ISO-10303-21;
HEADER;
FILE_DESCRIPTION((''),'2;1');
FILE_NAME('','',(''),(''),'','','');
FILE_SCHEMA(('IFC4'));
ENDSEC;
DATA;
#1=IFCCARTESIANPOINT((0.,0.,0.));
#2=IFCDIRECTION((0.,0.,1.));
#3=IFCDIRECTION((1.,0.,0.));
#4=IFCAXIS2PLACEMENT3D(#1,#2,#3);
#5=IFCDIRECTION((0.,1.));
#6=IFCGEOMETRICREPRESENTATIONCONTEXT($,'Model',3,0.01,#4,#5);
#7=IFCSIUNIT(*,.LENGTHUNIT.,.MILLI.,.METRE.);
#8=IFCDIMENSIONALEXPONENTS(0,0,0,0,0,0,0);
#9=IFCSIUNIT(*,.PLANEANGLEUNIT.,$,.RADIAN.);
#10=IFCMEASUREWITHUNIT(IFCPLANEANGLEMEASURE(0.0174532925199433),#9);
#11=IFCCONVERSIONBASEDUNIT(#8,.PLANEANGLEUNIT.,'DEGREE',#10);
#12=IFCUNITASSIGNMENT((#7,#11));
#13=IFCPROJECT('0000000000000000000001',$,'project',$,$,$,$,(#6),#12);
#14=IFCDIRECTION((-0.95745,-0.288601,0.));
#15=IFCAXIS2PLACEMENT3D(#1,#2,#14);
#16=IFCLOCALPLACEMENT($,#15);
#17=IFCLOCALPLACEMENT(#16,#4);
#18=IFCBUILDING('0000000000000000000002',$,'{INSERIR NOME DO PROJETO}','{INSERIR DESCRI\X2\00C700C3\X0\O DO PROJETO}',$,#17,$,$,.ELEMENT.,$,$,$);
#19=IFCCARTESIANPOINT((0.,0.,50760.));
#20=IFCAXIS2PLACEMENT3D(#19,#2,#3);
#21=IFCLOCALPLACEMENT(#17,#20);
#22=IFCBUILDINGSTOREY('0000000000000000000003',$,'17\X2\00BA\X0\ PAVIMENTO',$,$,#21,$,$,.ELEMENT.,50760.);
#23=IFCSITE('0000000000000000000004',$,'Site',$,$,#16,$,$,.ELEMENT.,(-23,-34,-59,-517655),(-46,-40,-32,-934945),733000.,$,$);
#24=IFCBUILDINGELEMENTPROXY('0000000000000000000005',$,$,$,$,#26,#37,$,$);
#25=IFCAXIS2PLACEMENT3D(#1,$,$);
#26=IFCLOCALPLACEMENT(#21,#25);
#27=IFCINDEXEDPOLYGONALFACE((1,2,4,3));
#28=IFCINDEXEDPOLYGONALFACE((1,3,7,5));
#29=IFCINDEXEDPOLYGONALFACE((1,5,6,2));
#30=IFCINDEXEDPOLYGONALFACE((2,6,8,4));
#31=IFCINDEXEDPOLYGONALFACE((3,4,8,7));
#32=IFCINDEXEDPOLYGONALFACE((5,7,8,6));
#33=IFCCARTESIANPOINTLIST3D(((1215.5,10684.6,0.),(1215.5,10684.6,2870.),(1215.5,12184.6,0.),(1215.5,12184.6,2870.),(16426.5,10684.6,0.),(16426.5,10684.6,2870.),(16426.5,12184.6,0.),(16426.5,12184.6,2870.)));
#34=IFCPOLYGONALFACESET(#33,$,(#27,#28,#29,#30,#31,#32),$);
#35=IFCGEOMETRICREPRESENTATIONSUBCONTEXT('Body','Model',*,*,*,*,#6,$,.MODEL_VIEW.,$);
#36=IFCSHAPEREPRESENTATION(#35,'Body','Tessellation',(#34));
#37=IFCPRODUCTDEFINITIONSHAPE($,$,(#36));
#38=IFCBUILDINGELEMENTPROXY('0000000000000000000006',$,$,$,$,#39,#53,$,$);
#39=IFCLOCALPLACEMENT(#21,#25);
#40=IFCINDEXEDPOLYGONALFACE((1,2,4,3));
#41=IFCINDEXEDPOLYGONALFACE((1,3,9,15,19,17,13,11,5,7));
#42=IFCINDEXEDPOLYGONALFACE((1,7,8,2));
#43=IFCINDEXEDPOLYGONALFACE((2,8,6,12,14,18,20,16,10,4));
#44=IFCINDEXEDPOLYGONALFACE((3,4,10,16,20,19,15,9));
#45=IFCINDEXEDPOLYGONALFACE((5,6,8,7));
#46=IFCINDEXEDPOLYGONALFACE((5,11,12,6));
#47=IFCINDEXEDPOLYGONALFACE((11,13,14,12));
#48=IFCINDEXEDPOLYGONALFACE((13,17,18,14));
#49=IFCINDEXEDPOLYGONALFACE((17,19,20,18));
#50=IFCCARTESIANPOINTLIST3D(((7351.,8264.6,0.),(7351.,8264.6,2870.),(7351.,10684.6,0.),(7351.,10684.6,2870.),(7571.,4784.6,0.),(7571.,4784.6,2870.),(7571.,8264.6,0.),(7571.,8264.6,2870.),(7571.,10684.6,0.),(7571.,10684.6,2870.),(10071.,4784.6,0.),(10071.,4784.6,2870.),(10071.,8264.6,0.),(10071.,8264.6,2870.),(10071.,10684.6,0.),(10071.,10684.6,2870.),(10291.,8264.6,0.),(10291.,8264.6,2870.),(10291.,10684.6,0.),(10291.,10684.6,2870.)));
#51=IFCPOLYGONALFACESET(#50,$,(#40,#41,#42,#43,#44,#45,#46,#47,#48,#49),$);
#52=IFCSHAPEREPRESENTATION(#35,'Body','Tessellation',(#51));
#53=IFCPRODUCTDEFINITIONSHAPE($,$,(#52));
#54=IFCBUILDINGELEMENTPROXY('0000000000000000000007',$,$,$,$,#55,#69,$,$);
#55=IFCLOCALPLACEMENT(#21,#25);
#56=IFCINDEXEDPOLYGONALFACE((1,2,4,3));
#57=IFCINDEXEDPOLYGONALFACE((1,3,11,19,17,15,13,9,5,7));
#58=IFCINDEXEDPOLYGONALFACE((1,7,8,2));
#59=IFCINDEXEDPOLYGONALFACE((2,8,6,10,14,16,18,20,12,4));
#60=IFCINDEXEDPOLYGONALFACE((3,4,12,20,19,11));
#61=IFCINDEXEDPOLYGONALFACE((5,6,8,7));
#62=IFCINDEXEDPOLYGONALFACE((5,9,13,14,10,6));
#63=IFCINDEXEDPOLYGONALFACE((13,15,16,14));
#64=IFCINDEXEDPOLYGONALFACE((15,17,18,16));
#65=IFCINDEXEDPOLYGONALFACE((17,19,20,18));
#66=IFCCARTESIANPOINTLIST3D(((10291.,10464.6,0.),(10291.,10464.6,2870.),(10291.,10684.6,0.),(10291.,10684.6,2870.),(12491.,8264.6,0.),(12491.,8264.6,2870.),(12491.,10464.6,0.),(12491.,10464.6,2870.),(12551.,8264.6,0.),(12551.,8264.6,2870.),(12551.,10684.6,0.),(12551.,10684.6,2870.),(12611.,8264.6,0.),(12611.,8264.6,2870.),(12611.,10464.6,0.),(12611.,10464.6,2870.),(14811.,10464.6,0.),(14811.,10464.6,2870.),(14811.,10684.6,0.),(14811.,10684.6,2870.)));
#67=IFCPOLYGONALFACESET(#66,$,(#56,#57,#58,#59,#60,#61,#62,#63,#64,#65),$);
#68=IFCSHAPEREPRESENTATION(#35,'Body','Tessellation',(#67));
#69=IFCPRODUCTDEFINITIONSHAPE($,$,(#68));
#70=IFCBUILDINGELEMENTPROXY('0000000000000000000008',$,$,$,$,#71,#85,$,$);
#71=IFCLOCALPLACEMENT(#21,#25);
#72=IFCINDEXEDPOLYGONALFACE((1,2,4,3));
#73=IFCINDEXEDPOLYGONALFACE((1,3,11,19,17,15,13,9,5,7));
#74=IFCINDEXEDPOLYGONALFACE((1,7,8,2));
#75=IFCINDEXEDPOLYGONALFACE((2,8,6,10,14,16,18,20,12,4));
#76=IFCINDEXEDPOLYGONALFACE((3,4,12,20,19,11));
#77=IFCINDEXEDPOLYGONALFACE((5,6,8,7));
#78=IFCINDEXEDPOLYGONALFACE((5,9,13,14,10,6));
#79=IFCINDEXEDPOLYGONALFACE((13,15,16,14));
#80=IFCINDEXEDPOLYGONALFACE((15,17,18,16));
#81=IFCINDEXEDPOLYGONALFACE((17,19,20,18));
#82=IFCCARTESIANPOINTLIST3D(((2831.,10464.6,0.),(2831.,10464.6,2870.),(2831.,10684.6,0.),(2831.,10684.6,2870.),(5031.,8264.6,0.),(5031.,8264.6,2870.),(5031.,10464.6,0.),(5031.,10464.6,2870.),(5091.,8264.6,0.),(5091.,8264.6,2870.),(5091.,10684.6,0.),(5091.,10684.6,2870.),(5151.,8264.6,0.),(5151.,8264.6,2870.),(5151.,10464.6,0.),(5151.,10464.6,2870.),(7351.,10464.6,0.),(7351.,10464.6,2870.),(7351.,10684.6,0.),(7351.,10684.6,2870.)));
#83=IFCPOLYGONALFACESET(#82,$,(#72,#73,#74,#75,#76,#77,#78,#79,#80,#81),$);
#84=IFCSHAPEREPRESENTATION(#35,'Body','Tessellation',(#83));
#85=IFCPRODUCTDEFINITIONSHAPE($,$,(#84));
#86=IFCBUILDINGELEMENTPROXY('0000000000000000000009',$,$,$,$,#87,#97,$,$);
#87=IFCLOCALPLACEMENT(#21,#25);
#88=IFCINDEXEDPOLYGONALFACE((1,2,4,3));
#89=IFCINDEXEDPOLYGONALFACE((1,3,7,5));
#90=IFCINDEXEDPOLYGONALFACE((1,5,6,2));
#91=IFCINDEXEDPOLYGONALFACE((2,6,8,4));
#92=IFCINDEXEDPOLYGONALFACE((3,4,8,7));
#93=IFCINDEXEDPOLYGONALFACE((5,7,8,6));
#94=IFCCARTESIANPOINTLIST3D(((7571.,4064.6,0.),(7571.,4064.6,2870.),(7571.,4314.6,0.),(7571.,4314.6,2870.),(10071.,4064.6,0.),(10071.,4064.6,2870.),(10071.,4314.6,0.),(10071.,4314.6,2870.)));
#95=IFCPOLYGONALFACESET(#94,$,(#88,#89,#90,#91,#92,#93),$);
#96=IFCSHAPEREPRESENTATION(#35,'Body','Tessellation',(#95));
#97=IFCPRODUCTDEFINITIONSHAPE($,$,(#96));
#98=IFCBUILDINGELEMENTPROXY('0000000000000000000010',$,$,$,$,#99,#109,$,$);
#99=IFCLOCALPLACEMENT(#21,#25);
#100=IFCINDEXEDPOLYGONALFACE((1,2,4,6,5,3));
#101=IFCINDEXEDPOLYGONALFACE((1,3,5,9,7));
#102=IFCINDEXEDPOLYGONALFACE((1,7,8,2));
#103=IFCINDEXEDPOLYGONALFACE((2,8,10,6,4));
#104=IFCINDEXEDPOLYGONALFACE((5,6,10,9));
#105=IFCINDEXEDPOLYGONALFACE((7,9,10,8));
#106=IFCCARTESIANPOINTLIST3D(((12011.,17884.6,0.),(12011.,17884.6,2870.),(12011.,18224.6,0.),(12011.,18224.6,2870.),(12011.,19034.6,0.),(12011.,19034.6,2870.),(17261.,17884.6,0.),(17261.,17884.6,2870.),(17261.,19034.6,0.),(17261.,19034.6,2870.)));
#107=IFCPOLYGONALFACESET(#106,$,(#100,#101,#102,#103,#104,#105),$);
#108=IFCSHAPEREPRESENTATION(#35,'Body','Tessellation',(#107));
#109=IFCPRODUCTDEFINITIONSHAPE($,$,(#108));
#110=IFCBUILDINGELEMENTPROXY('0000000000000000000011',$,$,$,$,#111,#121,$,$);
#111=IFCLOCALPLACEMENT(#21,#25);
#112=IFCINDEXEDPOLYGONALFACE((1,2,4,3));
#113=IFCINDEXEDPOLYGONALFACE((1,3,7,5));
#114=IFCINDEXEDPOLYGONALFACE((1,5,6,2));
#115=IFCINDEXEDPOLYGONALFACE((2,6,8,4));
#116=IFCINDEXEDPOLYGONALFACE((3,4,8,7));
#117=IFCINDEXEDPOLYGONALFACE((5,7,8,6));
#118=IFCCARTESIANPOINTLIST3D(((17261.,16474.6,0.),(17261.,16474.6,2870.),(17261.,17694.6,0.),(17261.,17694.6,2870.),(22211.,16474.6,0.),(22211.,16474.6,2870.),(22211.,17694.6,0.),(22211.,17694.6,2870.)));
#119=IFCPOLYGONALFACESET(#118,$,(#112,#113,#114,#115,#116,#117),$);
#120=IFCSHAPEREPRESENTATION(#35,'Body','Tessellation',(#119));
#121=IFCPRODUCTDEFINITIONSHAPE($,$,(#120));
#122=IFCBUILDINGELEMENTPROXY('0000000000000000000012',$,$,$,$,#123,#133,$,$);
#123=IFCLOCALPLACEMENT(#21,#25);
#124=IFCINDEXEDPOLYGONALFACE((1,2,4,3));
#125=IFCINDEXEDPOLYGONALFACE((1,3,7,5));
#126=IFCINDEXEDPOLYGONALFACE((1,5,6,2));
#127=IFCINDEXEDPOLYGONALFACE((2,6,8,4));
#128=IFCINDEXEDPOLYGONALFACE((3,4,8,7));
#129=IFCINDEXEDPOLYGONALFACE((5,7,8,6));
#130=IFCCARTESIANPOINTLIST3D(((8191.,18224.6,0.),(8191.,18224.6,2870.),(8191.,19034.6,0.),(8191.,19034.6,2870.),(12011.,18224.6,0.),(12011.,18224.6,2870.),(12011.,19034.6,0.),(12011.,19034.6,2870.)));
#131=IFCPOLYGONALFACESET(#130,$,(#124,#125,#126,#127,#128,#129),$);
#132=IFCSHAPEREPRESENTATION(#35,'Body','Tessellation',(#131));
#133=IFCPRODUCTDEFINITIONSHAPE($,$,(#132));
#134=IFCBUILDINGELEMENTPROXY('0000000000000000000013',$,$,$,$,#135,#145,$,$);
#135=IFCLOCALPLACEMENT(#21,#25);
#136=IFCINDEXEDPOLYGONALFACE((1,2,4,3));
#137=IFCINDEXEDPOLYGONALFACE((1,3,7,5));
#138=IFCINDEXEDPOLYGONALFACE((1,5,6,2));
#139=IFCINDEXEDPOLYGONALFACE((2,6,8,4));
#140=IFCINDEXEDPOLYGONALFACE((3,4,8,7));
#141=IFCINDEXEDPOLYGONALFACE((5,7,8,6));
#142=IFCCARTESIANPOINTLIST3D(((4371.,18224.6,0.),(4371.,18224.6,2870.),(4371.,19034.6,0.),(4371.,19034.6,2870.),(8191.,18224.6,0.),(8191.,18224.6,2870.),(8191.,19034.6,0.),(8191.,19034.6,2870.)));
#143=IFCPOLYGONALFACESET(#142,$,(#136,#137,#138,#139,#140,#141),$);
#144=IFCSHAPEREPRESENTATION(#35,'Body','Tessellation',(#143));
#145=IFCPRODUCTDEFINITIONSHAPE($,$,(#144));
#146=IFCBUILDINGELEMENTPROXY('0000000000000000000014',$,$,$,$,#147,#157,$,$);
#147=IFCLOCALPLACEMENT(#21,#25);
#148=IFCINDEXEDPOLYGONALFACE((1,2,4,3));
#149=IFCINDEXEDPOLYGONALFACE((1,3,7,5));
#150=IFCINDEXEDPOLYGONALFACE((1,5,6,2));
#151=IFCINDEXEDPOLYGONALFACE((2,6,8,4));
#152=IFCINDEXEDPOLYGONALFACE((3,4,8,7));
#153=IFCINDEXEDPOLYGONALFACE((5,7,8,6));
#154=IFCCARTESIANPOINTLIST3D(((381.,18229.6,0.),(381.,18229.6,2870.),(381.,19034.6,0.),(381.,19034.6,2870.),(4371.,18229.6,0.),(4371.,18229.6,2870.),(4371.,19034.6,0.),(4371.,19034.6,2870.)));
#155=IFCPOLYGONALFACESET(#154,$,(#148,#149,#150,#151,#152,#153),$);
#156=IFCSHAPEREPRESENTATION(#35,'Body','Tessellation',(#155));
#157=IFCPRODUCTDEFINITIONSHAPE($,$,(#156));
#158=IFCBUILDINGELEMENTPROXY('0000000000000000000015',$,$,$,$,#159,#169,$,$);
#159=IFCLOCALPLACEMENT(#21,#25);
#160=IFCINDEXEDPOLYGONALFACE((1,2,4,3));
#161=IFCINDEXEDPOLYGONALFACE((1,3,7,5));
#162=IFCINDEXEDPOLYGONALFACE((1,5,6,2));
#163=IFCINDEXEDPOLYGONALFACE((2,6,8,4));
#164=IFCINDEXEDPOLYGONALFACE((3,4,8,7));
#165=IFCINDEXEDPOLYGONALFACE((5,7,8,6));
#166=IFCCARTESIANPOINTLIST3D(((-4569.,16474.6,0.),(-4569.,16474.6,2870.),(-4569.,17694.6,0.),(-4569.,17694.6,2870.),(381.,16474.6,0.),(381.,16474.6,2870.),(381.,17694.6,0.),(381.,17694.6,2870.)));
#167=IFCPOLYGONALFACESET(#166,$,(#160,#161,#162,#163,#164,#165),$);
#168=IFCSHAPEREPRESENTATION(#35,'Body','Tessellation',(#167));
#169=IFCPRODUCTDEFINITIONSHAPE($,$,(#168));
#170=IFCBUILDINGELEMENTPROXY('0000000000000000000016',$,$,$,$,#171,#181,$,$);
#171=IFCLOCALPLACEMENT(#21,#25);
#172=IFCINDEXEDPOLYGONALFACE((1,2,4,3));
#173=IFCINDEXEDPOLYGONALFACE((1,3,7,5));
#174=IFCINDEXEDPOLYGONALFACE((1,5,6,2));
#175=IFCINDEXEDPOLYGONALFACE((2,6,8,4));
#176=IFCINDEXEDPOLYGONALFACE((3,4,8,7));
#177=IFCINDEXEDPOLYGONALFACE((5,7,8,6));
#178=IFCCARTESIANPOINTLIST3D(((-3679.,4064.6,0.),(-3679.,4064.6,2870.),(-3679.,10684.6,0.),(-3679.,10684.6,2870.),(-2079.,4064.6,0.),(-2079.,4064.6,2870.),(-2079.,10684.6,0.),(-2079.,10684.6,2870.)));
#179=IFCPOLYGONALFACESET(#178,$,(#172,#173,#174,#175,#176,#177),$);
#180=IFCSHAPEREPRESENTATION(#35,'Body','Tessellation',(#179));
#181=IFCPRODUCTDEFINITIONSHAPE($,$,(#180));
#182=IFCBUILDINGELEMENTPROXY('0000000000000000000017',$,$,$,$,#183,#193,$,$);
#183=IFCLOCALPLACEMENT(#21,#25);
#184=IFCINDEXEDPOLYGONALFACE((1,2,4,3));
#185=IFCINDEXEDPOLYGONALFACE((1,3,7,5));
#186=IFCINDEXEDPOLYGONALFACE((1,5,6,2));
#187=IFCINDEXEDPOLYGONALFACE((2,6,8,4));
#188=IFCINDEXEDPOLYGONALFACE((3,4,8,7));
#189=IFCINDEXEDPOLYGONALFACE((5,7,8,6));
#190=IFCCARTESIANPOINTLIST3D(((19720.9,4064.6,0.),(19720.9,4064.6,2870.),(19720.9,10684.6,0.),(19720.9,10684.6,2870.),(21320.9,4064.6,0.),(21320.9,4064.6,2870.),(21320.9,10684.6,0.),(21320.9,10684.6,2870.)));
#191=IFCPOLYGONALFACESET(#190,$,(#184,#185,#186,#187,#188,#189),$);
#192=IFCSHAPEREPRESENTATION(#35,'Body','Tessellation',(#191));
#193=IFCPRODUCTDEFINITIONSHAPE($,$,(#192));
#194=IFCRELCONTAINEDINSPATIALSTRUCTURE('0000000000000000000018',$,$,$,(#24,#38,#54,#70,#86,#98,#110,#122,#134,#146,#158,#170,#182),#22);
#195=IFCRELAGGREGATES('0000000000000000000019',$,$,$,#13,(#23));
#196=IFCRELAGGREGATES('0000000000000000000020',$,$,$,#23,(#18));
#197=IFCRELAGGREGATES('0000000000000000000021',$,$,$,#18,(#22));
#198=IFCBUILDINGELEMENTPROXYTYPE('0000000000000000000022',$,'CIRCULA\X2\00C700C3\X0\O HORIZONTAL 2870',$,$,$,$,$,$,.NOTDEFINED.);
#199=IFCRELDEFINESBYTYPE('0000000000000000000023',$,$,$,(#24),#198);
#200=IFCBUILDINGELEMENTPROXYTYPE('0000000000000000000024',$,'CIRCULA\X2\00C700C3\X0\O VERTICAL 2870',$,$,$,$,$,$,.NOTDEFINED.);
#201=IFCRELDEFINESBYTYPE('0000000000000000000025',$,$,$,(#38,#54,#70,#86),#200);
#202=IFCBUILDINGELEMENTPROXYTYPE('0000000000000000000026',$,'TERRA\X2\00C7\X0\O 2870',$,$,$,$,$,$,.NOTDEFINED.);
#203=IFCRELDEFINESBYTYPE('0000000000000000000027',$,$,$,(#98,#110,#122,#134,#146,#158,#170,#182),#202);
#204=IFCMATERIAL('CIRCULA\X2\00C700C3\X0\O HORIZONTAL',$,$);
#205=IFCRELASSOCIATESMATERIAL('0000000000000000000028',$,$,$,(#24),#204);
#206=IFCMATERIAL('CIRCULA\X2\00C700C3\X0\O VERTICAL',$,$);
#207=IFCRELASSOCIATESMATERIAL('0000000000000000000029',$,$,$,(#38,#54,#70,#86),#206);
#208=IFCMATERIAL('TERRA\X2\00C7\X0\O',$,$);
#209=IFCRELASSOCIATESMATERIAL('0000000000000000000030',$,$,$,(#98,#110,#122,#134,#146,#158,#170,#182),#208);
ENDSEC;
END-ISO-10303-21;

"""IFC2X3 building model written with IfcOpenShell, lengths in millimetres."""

from ifc_helpers import new_model, entity, si_unit, converted_unit, direction, frame, origin_with_axes, place, context, subcontext, project, spatial, polyline, outline, extrude, material, type_object, element, save


model = new_model("IFC2X3")

# Units and contexts
model_context = context("Model", 3, precision=0.01, world=origin_with_axes(), true_north=direction((0.0, 1.0)))
body_context = subcontext(model_context, "Body", "Model", "MODEL_VIEW")
ifc_project = project(units=[si_unit("LENGTHUNIT", "METRE", prefix="MILLI"), converted_unit("PLANEANGLEUNIT", "DEGREE", entity("IfcPlaneAngleMeasure", 0.0174532925199433), si_unit("PLANEANGLEUNIT", "RADIAN"), dimensions=[0, 0, 0, 0, 0, 0, 0])], contexts=[model_context])

# Site, building, storey
site_placement = place(None, frame((0.0, 0.0, 0.0), z_axis=(0.0, 0.0, 1.0), x_axis=(-0.95745, -0.288601, 0.0)))
site = spatial("IfcSite", under=ifc_project, at=site_placement, Name="Site", CompositionType="ELEMENT", RefLatitude=(-23, -34, -59, -517655), RefLongitude=(-46, -40, -32, -934945), RefElevation=733000.0)
building_placement = place(site_placement, origin_with_axes())
building = spatial("IfcBuilding", under=site, at=building_placement, Name="{INSERIR NOME DO PROJETO}", Description="{INSERIR DESCRIÇÃO DO PROJETO}", CompositionType="ELEMENT")
storey_placement = place(building_placement, frame((0.0, 0.0, 50760.0), z_axis=(0.0, 0.0, 1.0), x_axis=(1.0, 0.0, 0.0)))
storey = spatial("IfcBuildingStorey", under=building, at=storey_placement, Name="17º PAVIMENTO", CompositionType="ELEMENT", Elevation=50760.0)

# Building element proxies
ifc_material_1 = material(Name="CIRCULAÇÃO HORIZONTAL")
building_element_proxy_type_1 = type_object("IfcBuildingElementProxyType", Name="CIRCULAÇÃO HORIZONTAL 2870", PredefinedType="NOTDEFINED")
proxy_1_placement = place(storey_placement, frame((1215.5, 10684.6, 0.0), z_axis=(0.0, 0.0, 1.0), x_axis=(1.0, 0.0, 0.0)))
element("IfcBuildingElementProxy", 1, at=proxy_1_placement, inside=storey, type_object=building_element_proxy_type_1, material=ifc_material_1, context=body_context, shape_type="SweptSolid", body=[
    extrude(outline(polyline([(0.0, 0.0), (15211.0, 0.0), (15211.0, 1500.0), (0.0, 1500.0), (0.0, 0.0)])), origin_with_axes(), (0.0, 0.0, 1.0), 2870.0),
])
ifc_material_2 = material(Name="CIRCULAÇÃO VERTICAL")
building_element_proxy_type_2 = type_object("IfcBuildingElementProxyType", Name="CIRCULAÇÃO VERTICAL 2870", PredefinedType="NOTDEFINED")
proxy_2_placement = place(storey_placement, frame((7351.0, 10684.6, 0.0), z_axis=(0.0, 0.0, 1.0), x_axis=(1.0, 0.0, 0.0)))
element("IfcBuildingElementProxy", 2, at=proxy_2_placement, inside=storey, type_object=building_element_proxy_type_2, material=ifc_material_2, context=body_context, shape_type="SweptSolid", body=[
    extrude(outline(polyline([(0.0, 0.0), (0.0, -2420.0), (220.0, -2420.0), (220.0, -5900.0), (2720.0, -5900.0), (2720.0, -2420.0), (2940.0, -2420.0), (2940.0, 0.0), (2720.0, 0.0), (220.0, 0.0), (0.0, 0.0)])), origin_with_axes(), (0.0, 0.0, 1.0), 2870.0),
])
proxy_3_placement = place(storey_placement, frame((10291.0, 10684.6, 0.0), z_axis=(0.0, 0.0, 1.0), x_axis=(1.0, 0.0, 0.0)))
element("IfcBuildingElementProxy", 3, at=proxy_3_placement, inside=storey, type_object=building_element_proxy_type_2, material=ifc_material_2, context=body_context, shape_type="SweptSolid", body=[
    extrude(outline(polyline([(0.0, 0.0), (0.0, -220.0), (2200.0, -220.0), (2200.0, -2420.0), (2260.0, -2420.0), (2320.0, -2420.0), (2320.0, -220.0), (4520.0, -220.0), (4520.0, 0.0), (2260.0, 0.0), (0.0, 0.0)])), origin_with_axes(), (0.0, 0.0, 1.0), 2870.0),
])
proxy_4_placement = place(storey_placement, frame((5091.0, 10684.6, 0.0), z_axis=(0.0, 0.0, 1.0), x_axis=(1.0, 0.0, 0.0)))
element("IfcBuildingElementProxy", 4, at=proxy_4_placement, inside=storey, type_object=building_element_proxy_type_2, material=ifc_material_2, context=body_context, shape_type="SweptSolid", body=[
    extrude(outline(polyline([(0.0, 0.0), (-2260.0, 0.0), (-2260.0, -220.0), (-60.0, -220.0), (-60.0, -2420.0), (0.0, -2420.0), (60.0, -2420.0), (60.0, -220.0), (2260.0, -220.0), (2260.0, 0.0), (0.0, 0.0)])), origin_with_axes(), (0.0, 0.0, 1.0), 2870.0),
])
proxy_5_placement = place(storey_placement, frame((7571.0, 4064.6, 0.0), z_axis=(0.0, 0.0, 1.0), x_axis=(1.0, 0.0, 0.0)))
element("IfcBuildingElementProxy", 5, at=proxy_5_placement, inside=storey, type_object=building_element_proxy_type_2, material=ifc_material_2, context=body_context, shape_type="SweptSolid", body=[
    extrude(outline(polyline([(0.0, 0.0), (2500.0, 0.0), (2500.0, 250.0), (0.0, 250.0), (0.0, 0.0)])), origin_with_axes(), (0.0, 0.0, 1.0), 2870.0),
])
ifc_material_3 = material(Name="TERRAÇO")
building_element_proxy_type_3 = type_object("IfcBuildingElementProxyType", Name="TERRAÇO 2870", PredefinedType="NOTDEFINED")
proxy_6_placement = place(storey_placement, frame((12011.0, 19034.6, 0.0), z_axis=(0.0, 0.0, 1.0), x_axis=(1.0, 0.0, 0.0)))
element("IfcBuildingElementProxy", 6, at=proxy_6_placement, inside=storey, type_object=building_element_proxy_type_3, material=ifc_material_3, context=body_context, shape_type="SweptSolid", body=[
    extrude(outline(polyline([(0.0, 0.0), (0.0, -810.0), (0.0, -1150.0), (5250.0, -1150.0), (5250.0, 0.0), (0.0, 0.0)])), origin_with_axes(), (0.0, 0.0, 1.0), 2870.0),
])
proxy_7_placement = place(storey_placement, frame((17261.0, 16474.6, 0.0), z_axis=(0.0, 0.0, 1.0), x_axis=(1.0, 0.0, 0.0)))
element("IfcBuildingElementProxy", 7, at=proxy_7_placement, inside=storey, type_object=building_element_proxy_type_3, material=ifc_material_3, context=body_context, shape_type="SweptSolid", body=[
    extrude(outline(polyline([(0.0, 0.0), (4950.0, 0.0), (4950.0, 1220.0), (0.0, 1220.0), (0.0, 0.0)])), origin_with_axes(), (0.0, 0.0, 1.0), 2870.0),
])
for number, where, z_axis, x_axis in (
    (8, (8191.0, 18224.6, 0.0), (0.0, 0.0, 1.0), (1.0, 0.0, 0.0)),
    (9, (4371.0, 18224.6, 0.0), (0.0, 0.0, 1.0), (1.0, 0.0, 0.0)),
):
    element("IfcBuildingElementProxy", number, at=place(storey_placement, frame(where, z_axis=z_axis, x_axis=x_axis)), inside=storey, type_object=building_element_proxy_type_3, material=ifc_material_3, context=body_context, shape_type="SweptSolid", body=[
        extrude(outline(polyline([(0.0, 0.0), (3820.0, 0.0), (3820.0, 810.0), (0.0, 810.0), (0.0, 0.0)])), origin_with_axes(), (0.0, 0.0, 1.0), 2870.0),
    ])
proxy_8_placement = place(storey_placement, frame((381.0, 19034.6, 0.0), z_axis=(0.0, 0.0, 1.0), x_axis=(1.0, 0.0, 0.0)))
element("IfcBuildingElementProxy", 10, at=proxy_8_placement, inside=storey, type_object=building_element_proxy_type_3, material=ifc_material_3, context=body_context, shape_type="SweptSolid", body=[
    extrude(outline(polyline([(0.0, 0.0), (0.0, -805.0), (3990.0, -805.0), (3990.0, 0.0), (0.0, 0.0)])), origin_with_axes(), (0.0, 0.0, 1.0), 2870.0),
])
proxy_9_placement = place(storey_placement, frame((381.0, 17694.6, 0.0), z_axis=(0.0, 0.0, 1.0), x_axis=(1.0, 0.0, 0.0)))
element("IfcBuildingElementProxy", 11, at=proxy_9_placement, inside=storey, type_object=building_element_proxy_type_3, material=ifc_material_3, context=body_context, shape_type="SweptSolid", body=[
    extrude(outline(polyline([(0.0, 0.0), (-4950.0, 0.0), (-4950.0, -1220.0), (0.0, -1220.0), (0.0, 0.0)])), origin_with_axes(), (0.0, 0.0, 1.0), 2870.0),
])
proxy_10_placement = place(storey_placement, frame((-3679.0, 4064.6, 0.0), z_axis=(0.0, 0.0, 1.0), x_axis=(1.0, 0.0, 0.0)))
element("IfcBuildingElementProxy", 12, at=proxy_10_placement, inside=storey, type_object=building_element_proxy_type_3, material=ifc_material_3, context=body_context, shape_type="SweptSolid", body=[
    extrude(outline(polyline([(0.0, 0.0), (1600.0, 0.0), (1600.0, 6620.0), (0.0, 6620.0), (0.0, 0.0)])), origin_with_axes(), (0.0, 0.0, 1.0), 2870.0),
])
proxy_11_placement = place(storey_placement, frame((21320.9, 4064.6, 0.0), z_axis=(0.0, 0.0, 1.0), x_axis=(1.0, 0.0, 0.0)))
element("IfcBuildingElementProxy", 13, at=proxy_11_placement, inside=storey, type_object=building_element_proxy_type_3, material=ifc_material_3, context=body_context, shape_type="SweptSolid", body=[
    extrude(outline(polyline([(0.0, 0.0), (0.0, 6620.0), (-1600.0, 6620.0), (-1600.0, 0.0), (0.0, 0.0)])), origin_with_axes(), (0.0, 0.0, 1.0), 2870.0),
])

save(model, "model.ifc")
